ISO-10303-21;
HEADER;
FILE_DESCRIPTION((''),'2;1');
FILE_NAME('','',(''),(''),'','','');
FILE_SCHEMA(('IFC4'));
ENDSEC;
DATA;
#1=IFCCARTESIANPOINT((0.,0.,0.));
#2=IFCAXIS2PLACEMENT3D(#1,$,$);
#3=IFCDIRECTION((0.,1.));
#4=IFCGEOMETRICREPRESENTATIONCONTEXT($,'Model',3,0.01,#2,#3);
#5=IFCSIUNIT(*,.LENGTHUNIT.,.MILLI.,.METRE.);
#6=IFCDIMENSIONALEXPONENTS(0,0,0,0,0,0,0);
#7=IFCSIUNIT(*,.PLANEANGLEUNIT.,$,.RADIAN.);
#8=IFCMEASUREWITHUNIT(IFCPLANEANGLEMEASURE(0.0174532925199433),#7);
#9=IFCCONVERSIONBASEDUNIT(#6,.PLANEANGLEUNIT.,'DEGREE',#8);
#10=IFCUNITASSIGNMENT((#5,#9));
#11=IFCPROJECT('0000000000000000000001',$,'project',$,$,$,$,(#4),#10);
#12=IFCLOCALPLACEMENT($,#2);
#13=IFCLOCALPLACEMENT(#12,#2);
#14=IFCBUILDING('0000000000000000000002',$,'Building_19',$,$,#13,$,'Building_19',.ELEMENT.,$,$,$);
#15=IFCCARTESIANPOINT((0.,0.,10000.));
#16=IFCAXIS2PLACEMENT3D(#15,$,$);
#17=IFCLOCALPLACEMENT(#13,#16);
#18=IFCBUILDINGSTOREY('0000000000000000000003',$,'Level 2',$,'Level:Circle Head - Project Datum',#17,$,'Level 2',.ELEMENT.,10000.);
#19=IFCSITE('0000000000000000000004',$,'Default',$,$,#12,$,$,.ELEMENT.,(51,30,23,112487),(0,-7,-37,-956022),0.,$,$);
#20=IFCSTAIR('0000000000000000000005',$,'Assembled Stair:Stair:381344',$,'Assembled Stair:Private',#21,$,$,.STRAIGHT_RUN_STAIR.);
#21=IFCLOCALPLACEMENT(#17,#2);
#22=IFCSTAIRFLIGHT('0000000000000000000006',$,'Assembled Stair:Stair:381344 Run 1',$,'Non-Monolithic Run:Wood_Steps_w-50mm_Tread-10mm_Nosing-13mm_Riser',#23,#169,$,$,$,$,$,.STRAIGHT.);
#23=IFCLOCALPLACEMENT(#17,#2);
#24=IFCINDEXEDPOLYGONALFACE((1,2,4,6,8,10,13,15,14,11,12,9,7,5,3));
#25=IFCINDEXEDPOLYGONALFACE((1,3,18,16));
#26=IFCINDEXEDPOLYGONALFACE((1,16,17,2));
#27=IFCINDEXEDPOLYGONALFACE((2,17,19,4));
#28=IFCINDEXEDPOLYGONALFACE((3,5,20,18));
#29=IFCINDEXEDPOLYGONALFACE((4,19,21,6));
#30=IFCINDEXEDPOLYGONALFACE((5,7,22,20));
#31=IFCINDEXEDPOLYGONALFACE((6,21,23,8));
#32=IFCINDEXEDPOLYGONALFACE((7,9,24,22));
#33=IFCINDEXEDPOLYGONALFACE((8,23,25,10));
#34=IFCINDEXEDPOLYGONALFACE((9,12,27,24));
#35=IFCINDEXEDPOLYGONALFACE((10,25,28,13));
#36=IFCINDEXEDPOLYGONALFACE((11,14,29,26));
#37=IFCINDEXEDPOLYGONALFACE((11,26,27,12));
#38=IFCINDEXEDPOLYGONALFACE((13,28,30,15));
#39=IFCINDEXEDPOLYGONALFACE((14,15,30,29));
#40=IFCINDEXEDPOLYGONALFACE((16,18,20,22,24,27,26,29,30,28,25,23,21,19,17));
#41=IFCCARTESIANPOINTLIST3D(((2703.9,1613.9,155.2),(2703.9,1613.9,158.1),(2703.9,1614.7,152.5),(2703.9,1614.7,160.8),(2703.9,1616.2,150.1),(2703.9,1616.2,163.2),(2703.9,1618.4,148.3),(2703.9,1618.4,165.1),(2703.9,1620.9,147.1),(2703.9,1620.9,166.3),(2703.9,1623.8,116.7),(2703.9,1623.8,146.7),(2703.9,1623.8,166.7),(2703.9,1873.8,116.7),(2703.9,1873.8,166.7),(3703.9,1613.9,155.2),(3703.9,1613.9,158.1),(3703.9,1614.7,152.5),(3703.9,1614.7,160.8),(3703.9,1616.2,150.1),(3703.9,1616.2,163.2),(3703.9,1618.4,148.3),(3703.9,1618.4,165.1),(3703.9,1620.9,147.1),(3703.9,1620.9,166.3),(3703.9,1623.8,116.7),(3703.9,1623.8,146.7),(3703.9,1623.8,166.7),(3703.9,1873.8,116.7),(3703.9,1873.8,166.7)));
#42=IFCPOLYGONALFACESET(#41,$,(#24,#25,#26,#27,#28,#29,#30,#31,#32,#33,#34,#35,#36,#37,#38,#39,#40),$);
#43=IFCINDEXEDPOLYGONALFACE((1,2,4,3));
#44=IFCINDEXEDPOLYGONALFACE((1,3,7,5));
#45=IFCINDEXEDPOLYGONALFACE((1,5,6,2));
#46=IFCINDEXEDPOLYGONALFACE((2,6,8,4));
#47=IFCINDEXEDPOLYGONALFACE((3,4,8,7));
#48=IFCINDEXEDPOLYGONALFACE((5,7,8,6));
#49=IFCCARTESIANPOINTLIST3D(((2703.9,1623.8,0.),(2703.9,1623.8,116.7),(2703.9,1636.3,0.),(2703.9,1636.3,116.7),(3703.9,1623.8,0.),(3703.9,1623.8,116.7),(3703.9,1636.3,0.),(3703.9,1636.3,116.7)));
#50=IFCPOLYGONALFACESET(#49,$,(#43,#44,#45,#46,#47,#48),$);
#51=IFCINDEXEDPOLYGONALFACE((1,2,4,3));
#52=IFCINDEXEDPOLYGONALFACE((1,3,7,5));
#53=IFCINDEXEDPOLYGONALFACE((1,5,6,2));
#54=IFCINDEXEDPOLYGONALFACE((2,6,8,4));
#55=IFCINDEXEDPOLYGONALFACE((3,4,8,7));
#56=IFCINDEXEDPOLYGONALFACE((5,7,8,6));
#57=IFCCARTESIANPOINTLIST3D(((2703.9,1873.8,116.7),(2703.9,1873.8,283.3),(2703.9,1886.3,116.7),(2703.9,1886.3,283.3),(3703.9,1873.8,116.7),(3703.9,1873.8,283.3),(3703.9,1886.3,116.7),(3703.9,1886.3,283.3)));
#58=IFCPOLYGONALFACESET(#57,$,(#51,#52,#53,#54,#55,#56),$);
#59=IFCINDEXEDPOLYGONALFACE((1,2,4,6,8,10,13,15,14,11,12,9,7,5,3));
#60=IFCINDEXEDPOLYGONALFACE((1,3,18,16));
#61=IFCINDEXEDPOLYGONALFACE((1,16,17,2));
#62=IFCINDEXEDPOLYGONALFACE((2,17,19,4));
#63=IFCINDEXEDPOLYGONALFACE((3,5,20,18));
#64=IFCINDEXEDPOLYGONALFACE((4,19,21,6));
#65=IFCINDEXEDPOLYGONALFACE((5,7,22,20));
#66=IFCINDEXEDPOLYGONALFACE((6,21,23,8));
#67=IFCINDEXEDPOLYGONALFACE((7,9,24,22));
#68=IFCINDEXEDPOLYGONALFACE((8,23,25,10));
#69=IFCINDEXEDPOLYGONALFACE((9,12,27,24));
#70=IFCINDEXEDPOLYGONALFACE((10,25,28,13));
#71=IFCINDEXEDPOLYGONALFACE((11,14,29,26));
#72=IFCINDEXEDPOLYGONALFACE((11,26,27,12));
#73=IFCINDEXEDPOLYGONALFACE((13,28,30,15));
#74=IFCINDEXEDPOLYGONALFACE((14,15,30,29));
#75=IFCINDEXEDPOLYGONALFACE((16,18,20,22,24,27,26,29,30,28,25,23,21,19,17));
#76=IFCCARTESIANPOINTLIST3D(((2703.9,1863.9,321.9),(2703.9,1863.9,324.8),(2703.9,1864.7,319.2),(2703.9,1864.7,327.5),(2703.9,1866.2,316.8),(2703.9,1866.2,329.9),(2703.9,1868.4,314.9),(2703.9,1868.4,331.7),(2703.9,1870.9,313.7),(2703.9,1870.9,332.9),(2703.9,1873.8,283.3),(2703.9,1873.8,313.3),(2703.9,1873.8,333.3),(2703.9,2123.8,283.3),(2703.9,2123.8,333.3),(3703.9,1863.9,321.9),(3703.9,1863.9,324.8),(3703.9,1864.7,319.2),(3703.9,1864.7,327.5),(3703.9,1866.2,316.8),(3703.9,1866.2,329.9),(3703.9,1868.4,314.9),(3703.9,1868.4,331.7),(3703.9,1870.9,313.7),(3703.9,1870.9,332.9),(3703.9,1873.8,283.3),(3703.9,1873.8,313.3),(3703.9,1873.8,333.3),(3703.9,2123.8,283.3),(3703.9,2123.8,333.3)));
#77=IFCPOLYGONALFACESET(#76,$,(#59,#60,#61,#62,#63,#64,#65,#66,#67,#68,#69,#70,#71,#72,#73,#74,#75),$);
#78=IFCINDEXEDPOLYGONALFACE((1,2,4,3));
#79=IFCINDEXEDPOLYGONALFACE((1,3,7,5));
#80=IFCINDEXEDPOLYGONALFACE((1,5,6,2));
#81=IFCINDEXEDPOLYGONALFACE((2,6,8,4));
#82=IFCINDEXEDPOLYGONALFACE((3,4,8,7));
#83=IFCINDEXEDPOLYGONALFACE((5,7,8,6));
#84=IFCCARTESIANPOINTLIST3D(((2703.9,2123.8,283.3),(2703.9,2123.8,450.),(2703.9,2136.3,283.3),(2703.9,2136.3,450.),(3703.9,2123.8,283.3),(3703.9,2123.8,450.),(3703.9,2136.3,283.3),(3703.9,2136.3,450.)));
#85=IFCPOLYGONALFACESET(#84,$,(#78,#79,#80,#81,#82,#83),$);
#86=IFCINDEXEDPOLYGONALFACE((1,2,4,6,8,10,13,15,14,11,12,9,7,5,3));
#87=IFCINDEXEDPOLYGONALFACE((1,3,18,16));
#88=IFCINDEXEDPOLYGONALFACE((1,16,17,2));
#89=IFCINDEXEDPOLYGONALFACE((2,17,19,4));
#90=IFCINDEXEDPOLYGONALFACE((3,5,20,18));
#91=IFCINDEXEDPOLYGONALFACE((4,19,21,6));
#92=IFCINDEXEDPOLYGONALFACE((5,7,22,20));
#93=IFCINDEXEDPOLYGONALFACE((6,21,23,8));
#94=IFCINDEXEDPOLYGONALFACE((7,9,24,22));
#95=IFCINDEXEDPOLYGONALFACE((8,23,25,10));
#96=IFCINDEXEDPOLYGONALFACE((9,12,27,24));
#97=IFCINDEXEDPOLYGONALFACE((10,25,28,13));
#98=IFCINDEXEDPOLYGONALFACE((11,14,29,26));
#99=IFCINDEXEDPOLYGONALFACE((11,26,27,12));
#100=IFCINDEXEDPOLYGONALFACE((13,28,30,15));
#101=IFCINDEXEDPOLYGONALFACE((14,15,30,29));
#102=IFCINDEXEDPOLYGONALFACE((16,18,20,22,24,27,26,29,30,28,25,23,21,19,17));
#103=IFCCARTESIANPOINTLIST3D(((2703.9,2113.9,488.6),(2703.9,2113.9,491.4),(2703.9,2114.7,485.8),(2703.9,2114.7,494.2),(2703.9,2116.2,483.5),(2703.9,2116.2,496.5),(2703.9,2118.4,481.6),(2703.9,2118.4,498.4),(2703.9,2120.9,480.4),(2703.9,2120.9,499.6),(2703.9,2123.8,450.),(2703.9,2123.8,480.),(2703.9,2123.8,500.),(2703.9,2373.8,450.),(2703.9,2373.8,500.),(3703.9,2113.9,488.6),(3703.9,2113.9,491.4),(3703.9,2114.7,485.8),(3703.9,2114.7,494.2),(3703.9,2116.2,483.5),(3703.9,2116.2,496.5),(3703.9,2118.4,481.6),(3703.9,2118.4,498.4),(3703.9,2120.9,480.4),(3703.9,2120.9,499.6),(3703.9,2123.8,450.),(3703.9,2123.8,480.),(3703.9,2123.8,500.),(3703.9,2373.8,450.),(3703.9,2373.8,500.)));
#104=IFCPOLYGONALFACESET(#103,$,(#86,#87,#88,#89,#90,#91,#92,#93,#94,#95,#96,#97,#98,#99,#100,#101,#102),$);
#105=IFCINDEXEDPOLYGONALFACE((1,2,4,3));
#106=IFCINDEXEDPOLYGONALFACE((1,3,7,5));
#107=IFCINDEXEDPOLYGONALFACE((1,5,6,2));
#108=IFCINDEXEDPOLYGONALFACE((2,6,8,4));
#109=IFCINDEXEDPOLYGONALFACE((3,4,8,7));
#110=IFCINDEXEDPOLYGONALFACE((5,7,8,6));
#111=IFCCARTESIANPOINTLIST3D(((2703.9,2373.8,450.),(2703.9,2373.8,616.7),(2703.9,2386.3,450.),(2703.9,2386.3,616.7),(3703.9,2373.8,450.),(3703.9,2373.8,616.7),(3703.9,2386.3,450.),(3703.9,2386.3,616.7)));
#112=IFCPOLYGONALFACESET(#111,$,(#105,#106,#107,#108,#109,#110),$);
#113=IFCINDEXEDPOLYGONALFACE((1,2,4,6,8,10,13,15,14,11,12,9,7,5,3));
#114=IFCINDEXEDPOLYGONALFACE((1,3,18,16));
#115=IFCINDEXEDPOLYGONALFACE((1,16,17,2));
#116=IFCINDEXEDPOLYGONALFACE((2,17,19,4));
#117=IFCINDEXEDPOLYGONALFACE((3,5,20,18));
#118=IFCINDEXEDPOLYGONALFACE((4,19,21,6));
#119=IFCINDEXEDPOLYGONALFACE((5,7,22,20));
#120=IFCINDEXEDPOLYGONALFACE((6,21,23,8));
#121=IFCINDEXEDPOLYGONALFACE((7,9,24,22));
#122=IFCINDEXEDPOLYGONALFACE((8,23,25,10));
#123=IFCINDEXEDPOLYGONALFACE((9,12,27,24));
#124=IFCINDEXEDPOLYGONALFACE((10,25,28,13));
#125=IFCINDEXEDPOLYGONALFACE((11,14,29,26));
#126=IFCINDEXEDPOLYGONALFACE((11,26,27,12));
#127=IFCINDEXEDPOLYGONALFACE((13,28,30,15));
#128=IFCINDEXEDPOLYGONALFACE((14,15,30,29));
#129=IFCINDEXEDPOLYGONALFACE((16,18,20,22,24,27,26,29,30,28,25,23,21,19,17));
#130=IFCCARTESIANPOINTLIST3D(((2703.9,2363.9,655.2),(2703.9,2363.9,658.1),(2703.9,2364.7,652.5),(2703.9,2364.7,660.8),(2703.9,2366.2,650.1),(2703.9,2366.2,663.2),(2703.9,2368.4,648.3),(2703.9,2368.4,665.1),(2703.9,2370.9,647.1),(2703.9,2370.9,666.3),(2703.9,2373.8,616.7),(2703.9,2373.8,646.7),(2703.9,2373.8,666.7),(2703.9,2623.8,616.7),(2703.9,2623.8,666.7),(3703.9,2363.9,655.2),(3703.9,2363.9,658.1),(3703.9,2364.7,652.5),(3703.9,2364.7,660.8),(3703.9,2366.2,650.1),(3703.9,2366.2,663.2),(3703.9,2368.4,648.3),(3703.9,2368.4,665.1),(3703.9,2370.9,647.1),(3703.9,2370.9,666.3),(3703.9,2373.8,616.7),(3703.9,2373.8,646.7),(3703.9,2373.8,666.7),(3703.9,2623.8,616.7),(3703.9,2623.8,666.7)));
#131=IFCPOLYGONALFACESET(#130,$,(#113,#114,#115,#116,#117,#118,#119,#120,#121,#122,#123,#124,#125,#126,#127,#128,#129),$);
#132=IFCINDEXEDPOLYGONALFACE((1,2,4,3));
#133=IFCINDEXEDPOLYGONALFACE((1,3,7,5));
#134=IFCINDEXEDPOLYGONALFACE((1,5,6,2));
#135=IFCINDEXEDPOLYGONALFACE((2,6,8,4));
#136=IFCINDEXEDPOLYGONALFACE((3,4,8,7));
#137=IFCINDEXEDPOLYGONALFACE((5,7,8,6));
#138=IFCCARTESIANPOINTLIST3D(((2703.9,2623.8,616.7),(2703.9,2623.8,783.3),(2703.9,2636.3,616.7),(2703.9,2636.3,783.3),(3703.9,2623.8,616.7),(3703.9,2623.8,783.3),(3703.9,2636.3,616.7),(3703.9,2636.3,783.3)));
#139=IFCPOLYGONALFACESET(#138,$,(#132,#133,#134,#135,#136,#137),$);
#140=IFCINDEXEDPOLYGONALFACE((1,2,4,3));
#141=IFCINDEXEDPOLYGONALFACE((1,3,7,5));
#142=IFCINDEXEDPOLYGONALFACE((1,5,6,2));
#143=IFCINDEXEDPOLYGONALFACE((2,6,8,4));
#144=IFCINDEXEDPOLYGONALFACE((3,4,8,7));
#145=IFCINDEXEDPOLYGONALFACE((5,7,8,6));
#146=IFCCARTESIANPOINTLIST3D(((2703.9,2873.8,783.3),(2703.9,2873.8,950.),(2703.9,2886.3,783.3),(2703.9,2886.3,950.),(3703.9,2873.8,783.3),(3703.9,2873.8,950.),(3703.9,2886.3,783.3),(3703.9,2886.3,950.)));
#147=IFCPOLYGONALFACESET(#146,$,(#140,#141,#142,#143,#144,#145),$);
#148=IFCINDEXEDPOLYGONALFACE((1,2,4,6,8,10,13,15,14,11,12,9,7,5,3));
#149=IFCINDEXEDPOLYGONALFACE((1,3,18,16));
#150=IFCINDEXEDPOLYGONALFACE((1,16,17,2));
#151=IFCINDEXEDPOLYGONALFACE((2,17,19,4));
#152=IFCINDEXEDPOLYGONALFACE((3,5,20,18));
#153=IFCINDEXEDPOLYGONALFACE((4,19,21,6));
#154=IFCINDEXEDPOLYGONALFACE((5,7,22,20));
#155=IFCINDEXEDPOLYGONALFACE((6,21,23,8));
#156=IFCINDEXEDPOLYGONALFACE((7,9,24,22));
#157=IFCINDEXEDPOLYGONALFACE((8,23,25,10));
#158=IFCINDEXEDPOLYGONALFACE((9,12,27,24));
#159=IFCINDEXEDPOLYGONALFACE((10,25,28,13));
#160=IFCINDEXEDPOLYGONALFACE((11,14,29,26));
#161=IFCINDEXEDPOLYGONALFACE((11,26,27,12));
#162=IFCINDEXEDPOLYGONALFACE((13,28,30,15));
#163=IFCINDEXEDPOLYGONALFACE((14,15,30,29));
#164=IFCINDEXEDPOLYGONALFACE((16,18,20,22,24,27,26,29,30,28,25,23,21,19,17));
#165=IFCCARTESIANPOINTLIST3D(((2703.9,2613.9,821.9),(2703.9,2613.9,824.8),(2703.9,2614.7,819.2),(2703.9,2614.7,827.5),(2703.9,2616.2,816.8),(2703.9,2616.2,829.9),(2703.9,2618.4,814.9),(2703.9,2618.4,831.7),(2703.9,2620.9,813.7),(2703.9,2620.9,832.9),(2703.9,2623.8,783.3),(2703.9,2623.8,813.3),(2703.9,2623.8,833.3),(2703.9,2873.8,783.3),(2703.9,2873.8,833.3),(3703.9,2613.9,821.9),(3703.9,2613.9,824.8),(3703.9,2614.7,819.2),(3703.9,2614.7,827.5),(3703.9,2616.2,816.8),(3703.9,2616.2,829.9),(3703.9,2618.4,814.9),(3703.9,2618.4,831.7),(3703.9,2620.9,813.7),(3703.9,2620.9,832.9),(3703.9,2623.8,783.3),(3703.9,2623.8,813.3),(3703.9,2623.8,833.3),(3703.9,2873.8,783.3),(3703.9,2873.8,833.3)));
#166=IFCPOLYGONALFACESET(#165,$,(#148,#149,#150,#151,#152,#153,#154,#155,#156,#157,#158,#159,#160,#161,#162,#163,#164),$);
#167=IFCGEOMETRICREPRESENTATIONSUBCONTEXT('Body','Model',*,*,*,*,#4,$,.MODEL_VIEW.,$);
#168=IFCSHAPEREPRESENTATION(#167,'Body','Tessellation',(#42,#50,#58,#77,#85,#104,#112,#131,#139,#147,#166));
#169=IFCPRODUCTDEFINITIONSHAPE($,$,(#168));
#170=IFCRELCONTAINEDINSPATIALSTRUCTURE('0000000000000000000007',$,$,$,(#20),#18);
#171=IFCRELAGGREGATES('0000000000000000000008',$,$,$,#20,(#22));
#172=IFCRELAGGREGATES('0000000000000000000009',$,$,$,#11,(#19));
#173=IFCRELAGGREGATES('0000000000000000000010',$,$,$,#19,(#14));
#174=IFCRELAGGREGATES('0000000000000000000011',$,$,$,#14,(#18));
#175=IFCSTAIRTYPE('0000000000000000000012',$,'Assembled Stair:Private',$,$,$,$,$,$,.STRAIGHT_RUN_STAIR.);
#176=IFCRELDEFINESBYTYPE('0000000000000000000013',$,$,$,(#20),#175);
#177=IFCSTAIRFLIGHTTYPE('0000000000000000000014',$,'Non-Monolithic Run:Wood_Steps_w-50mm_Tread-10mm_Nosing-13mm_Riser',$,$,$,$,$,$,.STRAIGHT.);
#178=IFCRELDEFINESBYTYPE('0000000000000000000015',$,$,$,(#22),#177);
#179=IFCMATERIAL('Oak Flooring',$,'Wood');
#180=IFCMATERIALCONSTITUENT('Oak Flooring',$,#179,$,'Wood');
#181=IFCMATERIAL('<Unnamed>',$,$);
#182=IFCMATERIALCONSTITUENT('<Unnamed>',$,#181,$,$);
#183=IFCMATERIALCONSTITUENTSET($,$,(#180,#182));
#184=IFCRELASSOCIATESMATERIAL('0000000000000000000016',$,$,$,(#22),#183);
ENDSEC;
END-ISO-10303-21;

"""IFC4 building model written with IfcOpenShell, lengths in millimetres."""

from ifc_helpers import new_model, entity, si_unit, converted_unit, direction, frame, origin, place, context, subcontext, project, spatial, line, arc, indexed_curve, outline, extrude, material, constituent, constituent_set, type_object, element, aggregate, save


model = new_model("IFC4")

# Units and contexts
model_context = context("Model", 3, precision=0.01, world=origin(), true_north=direction((0.0, 1.0)))
body_context = subcontext(model_context, "Body", "Model", "MODEL_VIEW")
ifc_project = project(units=[si_unit("LENGTHUNIT", "METRE", prefix="MILLI"), converted_unit("PLANEANGLEUNIT", "DEGREE", entity("IfcPlaneAngleMeasure", 0.0174532925199433), si_unit("PLANEANGLEUNIT", "RADIAN"), dimensions=[0, 0, 0, 0, 0, 0, 0])], contexts=[model_context])

# Site, building, storey
site_placement = place(None, origin())
site = spatial("IfcSite", under=ifc_project, at=site_placement, Name="Default", CompositionType="ELEMENT", RefLatitude=(51, 30, 23, 112487), RefLongitude=(0, -7, -37, -956022), RefElevation=0.0)
building_placement = place(site_placement, origin())
building = spatial("IfcBuilding", under=site, at=building_placement, Name="Building_19", LongName="Building_19", CompositionType="ELEMENT")
storey_placement = place(building_placement, frame((0.0, 0.0, 10000.0)))
storey = spatial("IfcBuildingStorey", under=building, at=storey_placement, Name="Level 2", ObjectType="Level:Circle Head - Project Datum", LongName="Level 2", CompositionType="ELEMENT", Elevation=10000.0)

# Stair
stair_type = type_object("IfcStairType", Name="Assembled Stair:Private", PredefinedType="STRAIGHT_RUN_STAIR")
ifc_material_1 = material(Name="<Unnamed>")
stair_1_placement = place(storey_placement, origin())
stair_1 = element("IfcStair", 1, at=stair_1_placement, inside=storey, type_object=stair_type, Name="Assembled Stair:Stair:381344", ObjectType="Assembled Stair:Private", PredefinedType="STRAIGHT_RUN_STAIR")

# Stair flight
ifc_material_2 = material(Name="Oak Flooring", Category="Wood")
stair_flight_type = type_object("IfcStairFlightType", Name="Non-Monolithic Run:Wood_Steps_w-50mm_Tread-10mm_Nosing-13mm_Riser", PredefinedType="STRAIGHT")
ifc_constituent_1 = constituent(ifc_material_2, Name="Oak Flooring", Category="Wood")
ifc_constituent_2 = constituent(ifc_material_1, Name="<Unnamed>")
ifc_constituent_set_1 = constituent_set(constituents=[ifc_constituent_1, ifc_constituent_2])
stair_flight_1_placement = place(stair_1_placement, origin())
stair_flight_1 = element("IfcStairFlight", 2, at=stair_flight_1_placement, type_object=stair_flight_type, material=ifc_constituent_set_1, Name="Assembled Stair:Stair:381344 Run 1", ObjectType="Non-Monolithic Run:Wood_Steps_w-50mm_Tread-10mm_Nosing-13mm_Riser", PredefinedType="STRAIGHT", context=body_context, shape_type="SweptSolid", body=[
    extrude(outline(indexed_curve([(-100.0, 24.0), (-110.0, 14.0), (-100.0, 4.0), (-100.0, -26.0), (150.0, -26.0), (150.0, 24.0)], segments=[arc(1, 2, 3), line(3, 4, 5, 6, 1)], self_intersect=False)), frame((2703.9, 1723.8, 142.7), z_axis=(1.0, 0.0, 0.0), x_axis=(0.0, 1.0, 0.0)), (0.0, 0.0, 1.0), 1000.0),
    extrude(outline(indexed_curve([(-500.0, -6.2), (500.0, -6.2), (500.0, 6.3), (-500.0, 6.3), (-500.0, -6.2)], self_intersect=False)), frame((3203.9, 1630.0, 0.0), z_axis=(0.0, 0.0, 1.0), x_axis=(-1.0, 0.0, 0.0)), (0.0, 0.0, 1.0), 116.7),
    extrude(outline(indexed_curve([(-500.0, -6.2), (500.0, -6.2), (500.0, 6.3), (-500.0, 6.3), (-500.0, -6.2)], self_intersect=False)), frame((3203.9, 1880.0, 116.7), z_axis=(0.0, 0.0, 1.0), x_axis=(-1.0, 0.0, 0.0)), (0.0, 0.0, 1.0), 166.7),
    extrude(outline(indexed_curve([(-100.0, 24.0), (-110.0, 14.0), (-100.0, 4.0), (-100.0, -26.0), (150.0, -26.0), (150.0, 24.0)], segments=[arc(1, 2, 3), line(3, 4, 5, 6, 1)], self_intersect=False)), frame((2703.9, 1973.8, 309.3), z_axis=(1.0, 0.0, 0.0), x_axis=(0.0, 1.0, 0.0)), (0.0, 0.0, 1.0), 1000.0),
    extrude(outline(indexed_curve([(-500.0, -6.2), (500.0, -6.2), (500.0, 6.3), (-500.0, 6.3), (-500.0, -6.2)], self_intersect=False)), frame((3203.9, 2130.0, 283.3), z_axis=(0.0, 0.0, 1.0), x_axis=(-1.0, 0.0, 0.0)), (0.0, 0.0, 1.0), 166.7),
    extrude(outline(indexed_curve([(-100.0, 24.0), (-110.0, 14.0), (-100.0, 4.0), (-100.0, -26.0), (150.0, -26.0), (150.0, 24.0)], segments=[arc(1, 2, 3), line(3, 4, 5, 6, 1)], self_intersect=False)), frame((2703.9, 2223.8, 476.0), z_axis=(1.0, 0.0, 0.0), x_axis=(0.0, 1.0, 0.0)), (0.0, 0.0, 1.0), 1000.0),
    extrude(outline(indexed_curve([(-500.0, -6.2), (500.0, -6.2), (500.0, 6.3), (-500.0, 6.3), (-500.0, -6.2)], self_intersect=False)), frame((3203.9, 2380.0, 450.0), z_axis=(0.0, 0.0, 1.0), x_axis=(-1.0, 0.0, 0.0)), (0.0, 0.0, 1.0), 166.7),
    extrude(outline(indexed_curve([(-100.0, 24.0), (-110.0, 14.0), (-100.0, 4.0), (-100.0, -26.0), (150.0, -26.0), (150.0, 24.0)], segments=[arc(1, 2, 3), line(3, 4, 5, 6, 1)], self_intersect=False)), frame((2703.9, 2473.8, 642.7), z_axis=(1.0, 0.0, 0.0), x_axis=(0.0, 1.0, 0.0)), (0.0, 0.0, 1.0), 1000.0),
    extrude(outline(indexed_curve([(-500.0, -6.3), (500.0, -6.3), (500.0, 6.3), (-500.0, 6.3), (-500.0, -6.3)], self_intersect=False)), frame((3203.9, 2630.0, 616.7), z_axis=(0.0, 0.0, 1.0), x_axis=(-1.0, 0.0, 0.0)), (0.0, 0.0, 1.0), 166.7),
    extrude(outline(indexed_curve([(-500.0, -6.3), (500.0, -6.3), (500.0, 6.2), (-500.0, 6.2), (-500.0, -6.3)], self_intersect=False)), frame((3203.9, 2880.0, 783.3), z_axis=(0.0, 0.0, 1.0), x_axis=(-1.0, 0.0, 0.0)), (0.0, 0.0, 1.0), 166.7),
    extrude(outline(indexed_curve([(-100.0, 24.0), (-110.0, 14.0), (-100.0, 4.0), (-100.0, -26.0), (150.0, -26.0), (150.0, 24.0)], segments=[arc(1, 2, 3), line(3, 4, 5, 6, 1)], self_intersect=False)), frame((2703.9, 2723.8, 809.3), z_axis=(1.0, 0.0, 0.0), x_axis=(0.0, 1.0, 0.0)), (0.0, 0.0, 1.0), 1000.0),
])

aggregate(stair_1, [stair_flight_1])

save(model, "model.ifc")
